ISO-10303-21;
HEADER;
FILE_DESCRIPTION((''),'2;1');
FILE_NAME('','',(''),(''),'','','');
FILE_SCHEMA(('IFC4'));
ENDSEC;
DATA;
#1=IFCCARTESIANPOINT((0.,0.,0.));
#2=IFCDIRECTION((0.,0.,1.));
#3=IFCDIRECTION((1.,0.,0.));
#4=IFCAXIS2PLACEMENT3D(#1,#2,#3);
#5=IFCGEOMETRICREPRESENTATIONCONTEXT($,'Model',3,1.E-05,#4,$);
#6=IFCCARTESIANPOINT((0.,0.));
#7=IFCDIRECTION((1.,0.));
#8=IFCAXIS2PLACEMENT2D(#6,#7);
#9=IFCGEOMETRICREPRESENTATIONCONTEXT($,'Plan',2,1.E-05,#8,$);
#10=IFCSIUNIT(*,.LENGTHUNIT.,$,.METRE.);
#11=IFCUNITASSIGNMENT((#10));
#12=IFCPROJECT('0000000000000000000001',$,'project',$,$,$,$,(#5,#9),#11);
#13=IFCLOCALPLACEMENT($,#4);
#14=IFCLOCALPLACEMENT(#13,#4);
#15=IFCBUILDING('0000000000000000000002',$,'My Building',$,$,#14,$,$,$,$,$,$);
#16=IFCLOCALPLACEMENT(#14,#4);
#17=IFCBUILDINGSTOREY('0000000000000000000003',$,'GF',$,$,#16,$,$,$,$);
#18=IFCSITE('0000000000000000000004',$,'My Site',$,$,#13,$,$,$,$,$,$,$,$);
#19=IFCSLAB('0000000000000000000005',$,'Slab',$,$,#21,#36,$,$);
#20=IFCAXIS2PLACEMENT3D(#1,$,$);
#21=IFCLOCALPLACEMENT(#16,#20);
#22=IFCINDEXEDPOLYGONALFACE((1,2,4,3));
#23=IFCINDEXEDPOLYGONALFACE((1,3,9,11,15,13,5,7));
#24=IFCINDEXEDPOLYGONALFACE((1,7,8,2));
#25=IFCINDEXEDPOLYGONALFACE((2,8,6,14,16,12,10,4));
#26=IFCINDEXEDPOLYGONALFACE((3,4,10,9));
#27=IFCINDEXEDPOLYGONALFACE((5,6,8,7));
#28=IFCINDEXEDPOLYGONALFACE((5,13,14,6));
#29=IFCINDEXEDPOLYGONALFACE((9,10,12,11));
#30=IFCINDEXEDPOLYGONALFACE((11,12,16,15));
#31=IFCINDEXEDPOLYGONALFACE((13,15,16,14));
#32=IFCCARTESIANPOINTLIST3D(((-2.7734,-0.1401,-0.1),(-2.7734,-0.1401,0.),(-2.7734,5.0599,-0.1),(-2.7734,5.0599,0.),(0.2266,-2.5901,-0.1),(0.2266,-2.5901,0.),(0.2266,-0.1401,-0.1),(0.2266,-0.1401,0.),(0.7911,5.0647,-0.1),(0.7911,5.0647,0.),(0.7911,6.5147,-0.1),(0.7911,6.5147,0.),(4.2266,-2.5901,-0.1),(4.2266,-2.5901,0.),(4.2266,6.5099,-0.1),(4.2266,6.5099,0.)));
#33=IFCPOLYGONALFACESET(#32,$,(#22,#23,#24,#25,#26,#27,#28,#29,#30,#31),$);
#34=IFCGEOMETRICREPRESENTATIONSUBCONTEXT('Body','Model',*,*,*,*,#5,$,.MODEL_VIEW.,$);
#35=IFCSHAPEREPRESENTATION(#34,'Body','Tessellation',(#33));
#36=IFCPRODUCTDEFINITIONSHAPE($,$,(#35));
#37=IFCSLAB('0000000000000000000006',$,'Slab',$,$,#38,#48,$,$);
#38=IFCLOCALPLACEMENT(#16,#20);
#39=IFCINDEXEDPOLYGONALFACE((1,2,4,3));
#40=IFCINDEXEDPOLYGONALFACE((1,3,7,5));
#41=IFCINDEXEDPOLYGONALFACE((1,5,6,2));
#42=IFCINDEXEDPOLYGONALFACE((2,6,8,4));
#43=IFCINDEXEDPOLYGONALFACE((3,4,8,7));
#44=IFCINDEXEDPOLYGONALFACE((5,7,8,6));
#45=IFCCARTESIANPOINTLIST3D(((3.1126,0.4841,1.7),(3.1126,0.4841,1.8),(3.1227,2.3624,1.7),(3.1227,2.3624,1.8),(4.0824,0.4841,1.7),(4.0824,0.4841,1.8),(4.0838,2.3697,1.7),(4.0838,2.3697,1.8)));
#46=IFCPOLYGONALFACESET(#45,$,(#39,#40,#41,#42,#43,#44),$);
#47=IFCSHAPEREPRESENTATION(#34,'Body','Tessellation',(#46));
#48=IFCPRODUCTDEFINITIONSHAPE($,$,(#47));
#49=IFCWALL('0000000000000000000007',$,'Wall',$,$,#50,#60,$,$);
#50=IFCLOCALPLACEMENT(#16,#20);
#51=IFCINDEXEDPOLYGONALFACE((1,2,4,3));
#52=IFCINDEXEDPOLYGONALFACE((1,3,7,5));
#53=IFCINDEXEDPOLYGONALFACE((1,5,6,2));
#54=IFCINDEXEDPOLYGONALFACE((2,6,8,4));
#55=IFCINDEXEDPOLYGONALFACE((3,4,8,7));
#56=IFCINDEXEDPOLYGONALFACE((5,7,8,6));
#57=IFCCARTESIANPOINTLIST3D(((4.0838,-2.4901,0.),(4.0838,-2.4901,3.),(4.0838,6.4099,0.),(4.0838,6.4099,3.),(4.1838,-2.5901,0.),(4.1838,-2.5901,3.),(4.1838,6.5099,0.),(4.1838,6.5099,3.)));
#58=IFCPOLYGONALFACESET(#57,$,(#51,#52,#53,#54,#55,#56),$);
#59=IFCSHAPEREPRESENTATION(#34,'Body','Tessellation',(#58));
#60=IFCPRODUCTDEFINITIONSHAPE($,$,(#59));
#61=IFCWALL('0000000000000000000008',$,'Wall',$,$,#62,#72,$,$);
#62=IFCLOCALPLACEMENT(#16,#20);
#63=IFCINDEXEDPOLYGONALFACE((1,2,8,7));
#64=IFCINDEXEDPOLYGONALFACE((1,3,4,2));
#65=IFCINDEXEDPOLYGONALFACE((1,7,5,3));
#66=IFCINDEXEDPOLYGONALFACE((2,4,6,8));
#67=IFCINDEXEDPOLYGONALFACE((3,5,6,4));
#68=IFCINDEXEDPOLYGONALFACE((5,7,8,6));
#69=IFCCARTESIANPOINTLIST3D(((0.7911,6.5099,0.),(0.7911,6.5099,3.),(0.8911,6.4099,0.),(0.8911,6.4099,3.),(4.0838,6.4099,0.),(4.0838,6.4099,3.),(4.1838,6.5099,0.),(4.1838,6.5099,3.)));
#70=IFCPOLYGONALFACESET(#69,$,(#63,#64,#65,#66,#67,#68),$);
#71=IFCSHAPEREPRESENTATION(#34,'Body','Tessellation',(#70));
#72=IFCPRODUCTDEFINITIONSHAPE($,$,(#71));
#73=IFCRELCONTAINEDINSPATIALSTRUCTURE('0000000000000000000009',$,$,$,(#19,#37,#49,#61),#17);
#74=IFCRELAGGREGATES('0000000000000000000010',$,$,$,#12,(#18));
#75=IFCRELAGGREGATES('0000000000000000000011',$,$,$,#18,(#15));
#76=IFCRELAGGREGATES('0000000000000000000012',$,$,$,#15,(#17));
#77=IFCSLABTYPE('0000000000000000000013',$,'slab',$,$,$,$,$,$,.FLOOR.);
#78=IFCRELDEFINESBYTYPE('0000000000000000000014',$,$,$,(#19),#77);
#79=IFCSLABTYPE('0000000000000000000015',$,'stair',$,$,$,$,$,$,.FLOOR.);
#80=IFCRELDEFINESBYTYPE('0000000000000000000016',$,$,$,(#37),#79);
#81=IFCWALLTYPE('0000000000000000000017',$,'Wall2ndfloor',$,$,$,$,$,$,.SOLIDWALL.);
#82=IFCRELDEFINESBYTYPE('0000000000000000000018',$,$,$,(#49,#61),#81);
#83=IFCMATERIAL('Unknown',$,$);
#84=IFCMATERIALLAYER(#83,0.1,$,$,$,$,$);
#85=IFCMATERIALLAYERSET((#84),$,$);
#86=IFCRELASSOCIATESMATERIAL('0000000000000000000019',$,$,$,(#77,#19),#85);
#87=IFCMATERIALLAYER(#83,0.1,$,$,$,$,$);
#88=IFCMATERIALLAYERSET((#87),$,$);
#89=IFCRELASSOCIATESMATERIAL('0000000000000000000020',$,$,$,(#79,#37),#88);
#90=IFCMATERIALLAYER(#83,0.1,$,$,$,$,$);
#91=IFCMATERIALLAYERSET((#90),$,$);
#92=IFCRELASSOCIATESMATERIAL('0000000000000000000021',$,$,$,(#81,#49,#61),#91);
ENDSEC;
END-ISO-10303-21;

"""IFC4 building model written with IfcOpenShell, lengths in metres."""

from ifc_helpers import new_model, si_unit, frame, origin_with_axes, origin_2d_with_axis, place, context, subcontext, project, spatial, line, indexed_curve, outline, extrude, material, layer, layer_set, layer_usage, type_object, element, save


model = new_model("IFC4")

# Units and contexts
model_context = context("Model", 3, precision=1e-05, world=origin_with_axes())
plan_context = context("Plan", 2, precision=1e-05, world=origin_2d_with_axis())
body_context_1 = subcontext(model_context, "Body", "Model", "MODEL_VIEW")
ifc_project = project(units=[si_unit("LENGTHUNIT", "METRE")], contexts=[model_context, plan_context])

# Site, building, storey
site_placement = place(None, origin_with_axes())
site = spatial("IfcSite", under=ifc_project, at=site_placement, Name="My Site")
building_placement = place(site_placement, origin_with_axes())
building = spatial("IfcBuilding", under=site, at=building_placement, Name="My Building")
storey_placement = place(building_placement, origin_with_axes())
storey = spatial("IfcBuildingStorey", under=building, at=storey_placement, Name="GF")

# Slabs
ifc_material = material(Name="Unknown")
ifc_layer_1 = layer(ifc_material, 0.1)
ifc_layer_set_1 = layer_set([ifc_layer_1])
ifc_layer_usage_1 = layer_usage(ifc_layer_set_1, "AXIS3", "POSITIVE", -0.1)
slab_type_1 = type_object("IfcSlabType", Name="slab", PredefinedType="FLOOR", material=ifc_layer_set_1)
slab_1_placement = place(storey_placement, frame((0.2266, -2.5901, 0.0), z_axis=(0.0, 0.0, 1.0), x_axis=(1.0, 0.0, 0.0)))
element("IfcSlab", 1, at=slab_1_placement, inside=storey, type_object=slab_type_1, material=ifc_layer_usage_1, Name="Slab", context=body_context_1, shape_type="SweptSolid", body=[
    extrude(outline(indexed_curve([(0.0, 0.0), (4.0, 0.0), (4.0, 9.1), (0.5645, 9.1048), (0.5645, 7.6548), (-3.0, 7.65), (-3.0, 2.45), (0.0, 2.45), (0.0, 0.0)])), frame((0.0, 0.0, -0.1), z_axis=(0.0, 0.0, 1.0), x_axis=(1.0, 0.0, 0.0)), (0.0, 0.0, 1.0), 0.1),
])
ifc_layer_2 = layer(ifc_material, 0.1)
ifc_layer_set_2 = layer_set([ifc_layer_2])
ifc_layer_usage_2 = layer_usage(ifc_layer_set_2, "AXIS3", "POSITIVE", -0.1)
slab_type_2 = type_object("IfcSlabType", Name="stair", PredefinedType="FLOOR", material=ifc_layer_set_2)
slab_2_placement = place(storey_placement, frame((4.0824, 0.4841, 1.8), z_axis=(0.0, 0.0, 1.0), x_axis=(1.0, 0.0, 0.0)))
element("IfcSlab", 2, at=slab_2_placement, inside=storey, type_object=slab_type_2, material=ifc_layer_usage_2, Name="Slab", context=body_context_1, shape_type="SweptSolid", body=[
    extrude(outline(indexed_curve([(0.0, 0.0), (-0.9698, 0.0), (-0.9597, 1.8784), (0.0014, 1.8856), (0.0, 0.0)])), frame((0.0, 0.0, -0.1), z_axis=(0.0, 0.0, 1.0), x_axis=(1.0, 0.0, 0.0)), (0.0, 0.0, 1.0), 0.1),
])

# Shared definitions
ifc_layer_3 = layer(ifc_material, 0.1)
ifc_layer_set_3 = layer_set([ifc_layer_3])
wall_type_1 = type_object("IfcWallType", Name="Wall2ndfloor", PredefinedType="SOLIDWALL", material=ifc_layer_set_3)

# Walls
ifc_layer_usage_3 = layer_usage(ifc_layer_set_3, "AXIS2", "POSITIVE", 0.0)
wall_1_placement = place(storey_placement, frame((4.1838, -2.5901, 0.0), z_axis=(0.0, 0.0, 1.0), x_axis=(0.0, 1.0, 0.0)))
element("IfcWall", 3, at=wall_1_placement, inside=storey, type_object=wall_type_1, material=ifc_layer_usage_3, Name="Wall", context=body_context_1, shape_type="SweptSolid", body=[
    extrude(outline(indexed_curve([(0.0, 0.0), (0.1, 0.1), (9.0, 0.1), (9.1, 0.0)], segments=[line(1, 2, 3, 4, 1)])), origin_with_axes(), (0.0, 0.0, 1.0), 3.0),
])
ifc_layer_usage_4 = layer_usage(ifc_layer_set_3, "AXIS2", "POSITIVE", 0.0)
wall_2_placement = place(storey_placement, frame((4.1838, 6.5099, 0.0), z_axis=(0.0, 0.0, 1.0), x_axis=(-1.0, 0.0, 0.0)))
element("IfcWall", 4, at=wall_2_placement, inside=storey, type_object=wall_type_1, material=ifc_layer_usage_4, Name="Wall", context=body_context_1, shape_type="SweptSolid", body=[
    extrude(outline(indexed_curve([(0.0, 0.0), (0.1, 0.1), (3.2926, 0.1), (3.3926, 0.0)], segments=[line(1, 2, 3, 4, 1)])), origin_with_axes(), (0.0, 0.0, 1.0), 3.0),
])

save(model, "model.ifc")
